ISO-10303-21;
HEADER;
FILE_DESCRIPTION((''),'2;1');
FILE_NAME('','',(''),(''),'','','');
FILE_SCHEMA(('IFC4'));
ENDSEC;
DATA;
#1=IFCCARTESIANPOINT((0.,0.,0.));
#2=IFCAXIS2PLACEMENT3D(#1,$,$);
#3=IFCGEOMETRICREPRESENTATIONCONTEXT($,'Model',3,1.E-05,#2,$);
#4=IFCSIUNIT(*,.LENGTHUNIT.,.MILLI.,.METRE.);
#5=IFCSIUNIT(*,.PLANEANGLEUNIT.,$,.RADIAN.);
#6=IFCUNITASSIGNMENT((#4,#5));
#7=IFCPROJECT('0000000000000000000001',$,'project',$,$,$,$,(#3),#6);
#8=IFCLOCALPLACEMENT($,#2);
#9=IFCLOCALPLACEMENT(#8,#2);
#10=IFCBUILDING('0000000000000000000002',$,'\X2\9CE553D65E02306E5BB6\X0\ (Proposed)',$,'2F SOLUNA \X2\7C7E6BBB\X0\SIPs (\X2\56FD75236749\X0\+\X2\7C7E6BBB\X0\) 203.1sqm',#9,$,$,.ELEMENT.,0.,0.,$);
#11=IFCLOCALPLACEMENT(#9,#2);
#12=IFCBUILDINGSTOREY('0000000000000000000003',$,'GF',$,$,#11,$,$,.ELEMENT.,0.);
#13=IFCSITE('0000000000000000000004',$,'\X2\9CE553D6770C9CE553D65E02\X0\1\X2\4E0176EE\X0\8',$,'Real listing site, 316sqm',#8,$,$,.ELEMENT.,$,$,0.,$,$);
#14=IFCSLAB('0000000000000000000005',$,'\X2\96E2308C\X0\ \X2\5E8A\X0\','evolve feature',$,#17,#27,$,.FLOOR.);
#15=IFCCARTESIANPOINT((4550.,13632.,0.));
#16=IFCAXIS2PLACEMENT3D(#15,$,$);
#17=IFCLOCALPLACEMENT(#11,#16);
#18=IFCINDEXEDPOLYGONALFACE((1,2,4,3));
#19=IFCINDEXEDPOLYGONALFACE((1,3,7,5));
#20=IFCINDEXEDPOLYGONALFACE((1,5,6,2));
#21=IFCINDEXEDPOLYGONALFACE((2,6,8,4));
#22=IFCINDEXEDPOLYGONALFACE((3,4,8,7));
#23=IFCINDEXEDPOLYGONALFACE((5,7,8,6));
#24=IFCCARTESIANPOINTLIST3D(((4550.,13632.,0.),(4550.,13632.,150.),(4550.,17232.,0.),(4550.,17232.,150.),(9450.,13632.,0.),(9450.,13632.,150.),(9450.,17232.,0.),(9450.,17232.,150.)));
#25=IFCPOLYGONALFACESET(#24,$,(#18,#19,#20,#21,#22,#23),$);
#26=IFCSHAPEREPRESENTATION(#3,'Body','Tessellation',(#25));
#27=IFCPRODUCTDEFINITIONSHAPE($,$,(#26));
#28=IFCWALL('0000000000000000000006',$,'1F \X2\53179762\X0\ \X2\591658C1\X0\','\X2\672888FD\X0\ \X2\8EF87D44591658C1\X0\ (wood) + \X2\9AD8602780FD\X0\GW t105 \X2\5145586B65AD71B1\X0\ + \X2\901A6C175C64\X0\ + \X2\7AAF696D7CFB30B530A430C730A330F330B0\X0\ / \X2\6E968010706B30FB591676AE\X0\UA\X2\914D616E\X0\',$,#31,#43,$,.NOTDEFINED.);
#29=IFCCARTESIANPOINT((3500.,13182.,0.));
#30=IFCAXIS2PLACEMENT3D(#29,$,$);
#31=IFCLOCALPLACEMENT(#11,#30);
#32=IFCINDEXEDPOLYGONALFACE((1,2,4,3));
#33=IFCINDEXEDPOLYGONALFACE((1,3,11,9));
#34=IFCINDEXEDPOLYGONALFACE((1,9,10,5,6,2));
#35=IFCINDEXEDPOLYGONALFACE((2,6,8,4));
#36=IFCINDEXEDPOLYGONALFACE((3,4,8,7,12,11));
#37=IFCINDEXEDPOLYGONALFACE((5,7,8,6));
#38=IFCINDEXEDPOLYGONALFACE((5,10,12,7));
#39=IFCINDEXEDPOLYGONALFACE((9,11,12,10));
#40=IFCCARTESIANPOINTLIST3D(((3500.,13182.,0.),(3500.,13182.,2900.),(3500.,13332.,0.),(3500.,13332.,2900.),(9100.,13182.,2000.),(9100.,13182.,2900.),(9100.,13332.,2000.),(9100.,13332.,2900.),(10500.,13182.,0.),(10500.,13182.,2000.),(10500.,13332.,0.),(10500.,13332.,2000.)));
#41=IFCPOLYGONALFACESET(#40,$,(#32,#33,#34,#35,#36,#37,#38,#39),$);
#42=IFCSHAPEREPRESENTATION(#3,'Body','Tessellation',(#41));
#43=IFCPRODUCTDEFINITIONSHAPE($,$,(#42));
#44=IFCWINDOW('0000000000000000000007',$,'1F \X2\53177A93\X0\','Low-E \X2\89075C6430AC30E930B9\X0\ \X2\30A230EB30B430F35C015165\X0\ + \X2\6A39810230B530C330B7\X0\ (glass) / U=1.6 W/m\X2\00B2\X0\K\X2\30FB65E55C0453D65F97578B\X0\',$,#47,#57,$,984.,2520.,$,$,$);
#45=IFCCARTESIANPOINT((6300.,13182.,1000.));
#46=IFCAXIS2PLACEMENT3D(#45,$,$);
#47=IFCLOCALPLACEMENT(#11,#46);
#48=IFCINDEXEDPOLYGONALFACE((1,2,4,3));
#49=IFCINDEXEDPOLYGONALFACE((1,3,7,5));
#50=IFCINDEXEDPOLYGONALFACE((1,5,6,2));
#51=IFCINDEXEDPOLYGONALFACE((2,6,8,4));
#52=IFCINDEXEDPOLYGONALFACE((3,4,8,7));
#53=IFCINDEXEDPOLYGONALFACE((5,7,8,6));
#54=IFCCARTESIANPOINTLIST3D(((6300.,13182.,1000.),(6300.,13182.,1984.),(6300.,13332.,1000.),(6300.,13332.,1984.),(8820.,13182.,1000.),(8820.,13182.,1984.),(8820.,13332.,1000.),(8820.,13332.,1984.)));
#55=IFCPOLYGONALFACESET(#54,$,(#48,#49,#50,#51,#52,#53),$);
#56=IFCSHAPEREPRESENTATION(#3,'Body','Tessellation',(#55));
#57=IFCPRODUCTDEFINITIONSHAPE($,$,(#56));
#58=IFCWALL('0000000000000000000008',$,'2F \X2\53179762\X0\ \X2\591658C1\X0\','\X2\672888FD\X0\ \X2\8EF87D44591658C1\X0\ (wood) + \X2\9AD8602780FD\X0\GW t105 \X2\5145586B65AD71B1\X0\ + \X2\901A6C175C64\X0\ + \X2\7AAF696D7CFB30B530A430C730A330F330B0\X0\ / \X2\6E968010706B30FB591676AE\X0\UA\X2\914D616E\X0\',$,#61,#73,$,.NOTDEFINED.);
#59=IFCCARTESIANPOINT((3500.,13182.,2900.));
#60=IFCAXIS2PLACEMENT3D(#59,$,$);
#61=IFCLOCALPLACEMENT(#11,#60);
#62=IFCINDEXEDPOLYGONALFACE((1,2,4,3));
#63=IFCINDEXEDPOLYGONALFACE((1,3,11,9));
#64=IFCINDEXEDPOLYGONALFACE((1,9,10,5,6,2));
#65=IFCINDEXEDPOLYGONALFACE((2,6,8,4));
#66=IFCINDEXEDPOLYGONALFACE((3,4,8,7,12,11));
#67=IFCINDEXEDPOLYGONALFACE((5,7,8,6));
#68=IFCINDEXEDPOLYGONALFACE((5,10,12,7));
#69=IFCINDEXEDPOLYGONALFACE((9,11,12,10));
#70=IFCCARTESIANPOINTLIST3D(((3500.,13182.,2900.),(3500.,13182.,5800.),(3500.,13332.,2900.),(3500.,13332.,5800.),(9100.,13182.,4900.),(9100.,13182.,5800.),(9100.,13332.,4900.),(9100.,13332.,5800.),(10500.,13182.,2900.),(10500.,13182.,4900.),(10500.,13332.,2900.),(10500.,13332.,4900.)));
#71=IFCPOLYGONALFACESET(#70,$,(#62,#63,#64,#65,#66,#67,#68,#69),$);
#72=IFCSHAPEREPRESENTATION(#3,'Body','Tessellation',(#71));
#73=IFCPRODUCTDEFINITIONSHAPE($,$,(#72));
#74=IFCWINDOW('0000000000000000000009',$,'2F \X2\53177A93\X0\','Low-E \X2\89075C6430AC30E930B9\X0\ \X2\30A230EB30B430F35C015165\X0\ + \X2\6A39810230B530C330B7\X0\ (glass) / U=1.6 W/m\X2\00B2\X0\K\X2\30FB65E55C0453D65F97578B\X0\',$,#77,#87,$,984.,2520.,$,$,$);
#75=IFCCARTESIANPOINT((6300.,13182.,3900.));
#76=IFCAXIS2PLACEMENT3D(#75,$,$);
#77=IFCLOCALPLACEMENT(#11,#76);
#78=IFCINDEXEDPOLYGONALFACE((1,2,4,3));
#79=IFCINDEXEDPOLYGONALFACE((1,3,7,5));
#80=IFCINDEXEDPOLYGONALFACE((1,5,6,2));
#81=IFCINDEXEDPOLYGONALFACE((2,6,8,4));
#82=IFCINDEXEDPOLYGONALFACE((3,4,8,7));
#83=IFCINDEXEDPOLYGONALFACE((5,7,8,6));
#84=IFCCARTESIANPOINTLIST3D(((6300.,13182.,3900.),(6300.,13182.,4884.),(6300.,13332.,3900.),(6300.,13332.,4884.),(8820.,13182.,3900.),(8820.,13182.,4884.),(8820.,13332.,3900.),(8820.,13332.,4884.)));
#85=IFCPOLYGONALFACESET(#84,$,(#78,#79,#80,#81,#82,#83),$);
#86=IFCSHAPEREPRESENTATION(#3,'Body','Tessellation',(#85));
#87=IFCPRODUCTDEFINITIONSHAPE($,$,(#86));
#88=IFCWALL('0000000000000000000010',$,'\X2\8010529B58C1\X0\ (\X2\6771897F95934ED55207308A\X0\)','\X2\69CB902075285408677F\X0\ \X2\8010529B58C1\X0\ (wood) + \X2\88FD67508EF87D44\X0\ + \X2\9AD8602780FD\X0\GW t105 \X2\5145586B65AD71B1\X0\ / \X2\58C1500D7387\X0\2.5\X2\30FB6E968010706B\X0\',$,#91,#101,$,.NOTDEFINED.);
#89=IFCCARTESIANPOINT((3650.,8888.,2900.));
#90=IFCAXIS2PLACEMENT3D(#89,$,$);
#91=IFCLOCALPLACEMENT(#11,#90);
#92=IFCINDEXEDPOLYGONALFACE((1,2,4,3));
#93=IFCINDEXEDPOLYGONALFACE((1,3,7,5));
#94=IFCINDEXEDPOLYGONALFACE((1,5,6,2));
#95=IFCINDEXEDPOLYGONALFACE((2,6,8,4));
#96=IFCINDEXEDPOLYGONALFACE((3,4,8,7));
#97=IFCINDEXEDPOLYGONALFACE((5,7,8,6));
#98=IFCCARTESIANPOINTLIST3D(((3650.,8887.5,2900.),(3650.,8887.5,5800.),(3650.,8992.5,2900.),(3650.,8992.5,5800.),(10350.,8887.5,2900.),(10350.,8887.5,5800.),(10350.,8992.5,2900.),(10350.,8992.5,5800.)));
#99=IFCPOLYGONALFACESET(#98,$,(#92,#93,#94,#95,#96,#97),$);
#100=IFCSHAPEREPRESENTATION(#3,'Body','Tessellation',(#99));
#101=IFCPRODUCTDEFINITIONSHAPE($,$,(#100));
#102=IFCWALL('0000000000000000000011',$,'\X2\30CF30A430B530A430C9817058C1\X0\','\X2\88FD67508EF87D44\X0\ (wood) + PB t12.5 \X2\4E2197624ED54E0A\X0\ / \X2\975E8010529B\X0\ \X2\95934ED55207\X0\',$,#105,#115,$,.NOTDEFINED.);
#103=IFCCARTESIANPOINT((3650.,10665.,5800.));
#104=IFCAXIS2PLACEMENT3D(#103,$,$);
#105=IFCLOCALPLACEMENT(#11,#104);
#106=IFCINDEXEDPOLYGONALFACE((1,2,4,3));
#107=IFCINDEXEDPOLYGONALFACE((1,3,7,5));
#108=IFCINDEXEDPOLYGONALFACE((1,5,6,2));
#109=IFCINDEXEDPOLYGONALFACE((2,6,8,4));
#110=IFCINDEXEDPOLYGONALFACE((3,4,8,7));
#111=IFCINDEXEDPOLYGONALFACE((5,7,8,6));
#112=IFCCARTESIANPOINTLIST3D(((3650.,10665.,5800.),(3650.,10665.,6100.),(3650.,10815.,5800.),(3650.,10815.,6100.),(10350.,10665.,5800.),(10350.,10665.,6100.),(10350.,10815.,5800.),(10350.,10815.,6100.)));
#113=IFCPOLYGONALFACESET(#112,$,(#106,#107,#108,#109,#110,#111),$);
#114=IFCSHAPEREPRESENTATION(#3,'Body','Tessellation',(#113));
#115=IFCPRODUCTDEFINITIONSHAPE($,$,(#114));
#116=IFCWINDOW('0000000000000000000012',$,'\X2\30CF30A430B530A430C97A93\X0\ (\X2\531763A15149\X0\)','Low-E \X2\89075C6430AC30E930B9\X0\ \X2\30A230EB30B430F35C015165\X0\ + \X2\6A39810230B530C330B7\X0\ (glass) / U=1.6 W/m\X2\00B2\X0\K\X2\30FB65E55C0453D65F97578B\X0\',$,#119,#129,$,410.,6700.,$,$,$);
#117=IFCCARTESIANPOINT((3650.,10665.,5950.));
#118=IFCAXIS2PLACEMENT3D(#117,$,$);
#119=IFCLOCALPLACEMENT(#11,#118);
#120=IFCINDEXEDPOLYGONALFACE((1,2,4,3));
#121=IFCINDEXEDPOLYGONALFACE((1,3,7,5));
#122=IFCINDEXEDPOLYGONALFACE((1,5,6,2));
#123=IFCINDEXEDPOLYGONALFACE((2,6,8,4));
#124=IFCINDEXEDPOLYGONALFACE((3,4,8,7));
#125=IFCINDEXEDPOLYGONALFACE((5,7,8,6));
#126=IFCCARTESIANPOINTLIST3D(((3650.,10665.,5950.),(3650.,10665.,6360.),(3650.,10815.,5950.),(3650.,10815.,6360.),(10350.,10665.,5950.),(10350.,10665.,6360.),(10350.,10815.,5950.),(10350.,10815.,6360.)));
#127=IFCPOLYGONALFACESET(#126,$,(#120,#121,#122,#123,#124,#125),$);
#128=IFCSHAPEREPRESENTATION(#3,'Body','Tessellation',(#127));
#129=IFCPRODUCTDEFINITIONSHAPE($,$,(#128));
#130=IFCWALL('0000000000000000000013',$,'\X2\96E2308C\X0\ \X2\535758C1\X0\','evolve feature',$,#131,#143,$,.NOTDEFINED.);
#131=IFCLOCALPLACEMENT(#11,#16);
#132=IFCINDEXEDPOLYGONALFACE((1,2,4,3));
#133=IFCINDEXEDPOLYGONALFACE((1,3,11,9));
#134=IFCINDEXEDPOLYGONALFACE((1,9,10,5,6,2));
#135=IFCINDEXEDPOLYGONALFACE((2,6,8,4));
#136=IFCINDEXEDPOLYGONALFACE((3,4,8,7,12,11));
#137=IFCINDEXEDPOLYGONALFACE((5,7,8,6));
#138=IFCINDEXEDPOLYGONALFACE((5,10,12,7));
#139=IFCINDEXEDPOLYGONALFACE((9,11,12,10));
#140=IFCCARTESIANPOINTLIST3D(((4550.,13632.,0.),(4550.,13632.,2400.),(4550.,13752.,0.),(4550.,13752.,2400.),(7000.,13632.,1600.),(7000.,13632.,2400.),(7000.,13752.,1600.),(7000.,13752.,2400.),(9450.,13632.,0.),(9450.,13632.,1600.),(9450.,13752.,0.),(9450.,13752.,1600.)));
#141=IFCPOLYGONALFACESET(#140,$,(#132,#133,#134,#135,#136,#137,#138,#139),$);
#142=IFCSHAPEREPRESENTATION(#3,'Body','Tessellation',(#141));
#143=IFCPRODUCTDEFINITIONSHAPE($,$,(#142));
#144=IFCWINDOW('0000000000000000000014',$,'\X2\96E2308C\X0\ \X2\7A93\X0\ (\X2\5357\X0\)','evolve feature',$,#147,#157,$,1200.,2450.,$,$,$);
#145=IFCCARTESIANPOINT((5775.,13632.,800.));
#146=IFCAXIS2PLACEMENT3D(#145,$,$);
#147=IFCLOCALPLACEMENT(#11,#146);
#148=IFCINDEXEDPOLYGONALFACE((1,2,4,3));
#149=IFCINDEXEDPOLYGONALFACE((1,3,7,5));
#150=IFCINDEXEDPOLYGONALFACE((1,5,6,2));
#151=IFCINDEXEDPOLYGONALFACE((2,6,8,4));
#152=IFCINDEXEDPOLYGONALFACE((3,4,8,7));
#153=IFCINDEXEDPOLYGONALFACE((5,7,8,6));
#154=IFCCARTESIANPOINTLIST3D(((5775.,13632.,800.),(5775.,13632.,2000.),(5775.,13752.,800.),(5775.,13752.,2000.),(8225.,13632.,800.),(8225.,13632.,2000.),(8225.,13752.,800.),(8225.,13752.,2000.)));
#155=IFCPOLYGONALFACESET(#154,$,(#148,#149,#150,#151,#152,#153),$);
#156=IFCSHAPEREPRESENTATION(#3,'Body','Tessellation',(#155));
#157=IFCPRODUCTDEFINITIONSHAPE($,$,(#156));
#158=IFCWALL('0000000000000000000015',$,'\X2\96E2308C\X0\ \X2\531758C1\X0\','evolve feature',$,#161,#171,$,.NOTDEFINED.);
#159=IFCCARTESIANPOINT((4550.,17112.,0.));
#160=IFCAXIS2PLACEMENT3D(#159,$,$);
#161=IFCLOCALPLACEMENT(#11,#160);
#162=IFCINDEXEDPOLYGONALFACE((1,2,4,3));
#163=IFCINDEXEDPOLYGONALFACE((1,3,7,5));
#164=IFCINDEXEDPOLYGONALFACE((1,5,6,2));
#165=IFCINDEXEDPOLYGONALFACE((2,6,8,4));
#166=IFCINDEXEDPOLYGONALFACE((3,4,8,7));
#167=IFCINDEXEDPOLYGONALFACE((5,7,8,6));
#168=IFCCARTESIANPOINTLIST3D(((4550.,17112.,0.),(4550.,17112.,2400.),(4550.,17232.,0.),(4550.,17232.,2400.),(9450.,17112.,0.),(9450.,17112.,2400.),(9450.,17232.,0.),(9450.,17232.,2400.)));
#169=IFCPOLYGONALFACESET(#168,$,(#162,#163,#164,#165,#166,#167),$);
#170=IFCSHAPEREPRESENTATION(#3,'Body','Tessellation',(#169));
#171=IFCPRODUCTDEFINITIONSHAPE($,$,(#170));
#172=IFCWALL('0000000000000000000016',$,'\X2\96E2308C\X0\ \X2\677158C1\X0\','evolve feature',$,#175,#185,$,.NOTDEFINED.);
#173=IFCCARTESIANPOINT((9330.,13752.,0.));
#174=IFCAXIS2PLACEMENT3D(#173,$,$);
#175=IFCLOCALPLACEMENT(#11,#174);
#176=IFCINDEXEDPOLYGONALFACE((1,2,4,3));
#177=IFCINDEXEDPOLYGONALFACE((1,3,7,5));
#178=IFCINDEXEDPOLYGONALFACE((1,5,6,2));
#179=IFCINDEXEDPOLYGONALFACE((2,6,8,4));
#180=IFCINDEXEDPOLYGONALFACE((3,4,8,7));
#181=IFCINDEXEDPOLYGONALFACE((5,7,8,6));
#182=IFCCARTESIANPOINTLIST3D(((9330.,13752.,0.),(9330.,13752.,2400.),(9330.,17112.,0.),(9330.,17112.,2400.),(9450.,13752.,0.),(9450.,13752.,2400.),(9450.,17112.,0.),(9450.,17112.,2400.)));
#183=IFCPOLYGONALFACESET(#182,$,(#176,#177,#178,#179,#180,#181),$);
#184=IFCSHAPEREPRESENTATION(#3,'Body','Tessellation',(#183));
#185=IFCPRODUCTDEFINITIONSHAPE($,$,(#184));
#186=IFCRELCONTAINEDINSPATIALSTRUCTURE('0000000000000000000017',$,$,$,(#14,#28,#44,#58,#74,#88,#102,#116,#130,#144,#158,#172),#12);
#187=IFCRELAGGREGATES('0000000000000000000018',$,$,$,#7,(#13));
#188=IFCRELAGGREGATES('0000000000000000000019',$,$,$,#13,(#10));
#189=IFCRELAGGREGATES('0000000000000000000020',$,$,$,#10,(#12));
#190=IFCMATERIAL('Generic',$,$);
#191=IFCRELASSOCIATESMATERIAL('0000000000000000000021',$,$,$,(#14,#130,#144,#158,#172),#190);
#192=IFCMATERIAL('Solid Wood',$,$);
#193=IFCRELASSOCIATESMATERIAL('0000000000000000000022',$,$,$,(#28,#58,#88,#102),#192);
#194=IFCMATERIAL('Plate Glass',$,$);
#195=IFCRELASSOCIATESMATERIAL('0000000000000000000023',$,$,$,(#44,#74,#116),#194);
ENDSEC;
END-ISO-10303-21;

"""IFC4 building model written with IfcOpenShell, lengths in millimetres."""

from ifc_helpers import new_model, si_unit, frame, frame_2d, origin, place, context, project, spatial, rectangle, extrude, material, element, fill, save


model = new_model("IFC4")

# Units and contexts
model_context = context("Model", 3, precision=1e-05, world=origin())
ifc_project = project(units=[si_unit("LENGTHUNIT", "METRE", prefix="MILLI"), si_unit("PLANEANGLEUNIT", "RADIAN")], contexts=[model_context])

# Site, building, storey
site_placement = place(None, origin())
site = spatial("IfcSite", under=ifc_project, at=site_placement, Name="鳥取県鳥取市1丁目8", ObjectType="Real listing site, 316sqm", CompositionType="ELEMENT", RefElevation=0.0)
building_placement = place(site_placement, origin())
building = spatial("IfcBuilding", under=site, at=building_placement, Name="鳥取市の家 (Proposed)", ObjectType="2F SOLUNA 籾殻SIPs (国産杉+籾殻) 203.1sqm", CompositionType="ELEMENT", ElevationOfRefHeight=0.0, ElevationOfTerrain=0.0)
storey_placement = place(building_placement, origin())
storey = spatial("IfcBuildingStorey", under=building, at=storey_placement, Name="GF", CompositionType="ELEMENT", Elevation=0.0)

# Slab
ifc_material_1 = material(Name="Generic")
slab_placement = place(storey_placement, frame((4550.0, 13632.0, 0.0)))
element("IfcSlab", 1, at=slab_placement, inside=storey, material=ifc_material_1, Name="離れ 床", Description="evolve feature", PredefinedType="FLOOR", context=model_context, shape_type="SweptSolid", body=[
    extrude(rectangle(XDim=4900.0, YDim=3600.0, at=frame_2d((2450.0, 1800.0))), frame((4550.0, 13632.0, 0.0)), (0.0, 0.0, 1.0), 150.0),
])

# Wall, opening, window
ifc_material_2 = material(Name="Solid Wood")
wall_1_placement = place(storey_placement, frame((3500.0, 13182.0, 0.0)))
wall_1 = element("IfcWall", 2, at=wall_1_placement, inside=storey, material=ifc_material_2, Name="1F 北面 外壁", Description="木製 軸組外壁 (wood) + 高性能GW t105 充填断熱 + 通気層 + 窯業系サイディング / 準耐火・外皮UA配慮", PredefinedType="NOTDEFINED", context=model_context, shape_type="SweptSolid", body=[
    extrude(rectangle(XDim=7000.0, YDim=150.0, at=frame_2d((3500.0, 75.0))), frame((3500.0, 13182.0, 0.0)), (0.0, 0.0, 1.0), 2900.0),
])
opening_1_placement = place(storey_placement, frame((6300.0, 13182.0, 1000.0)))
opening_1 = element("IfcOpeningElement", 3, at=opening_1_placement, cuts=wall_1, PredefinedType="NOTDEFINED", context=model_context, shape_type="SweptSolid", body=[
    extrude(rectangle(XDim=2520.0, YDim=150.0, at=frame_2d((1260.0, 75.0))), frame((6300.0, 13182.0, 1000.0)), (0.0, 0.0, 1.0), 984.0),
])
ifc_material_3 = material(Name="Plate Glass")
window_1_placement = place(storey_placement, frame((6300.0, 13182.0, 1000.0)))
window_1 = element("IfcWindow", 4, at=window_1_placement, inside=storey, material=ifc_material_3, Name="1F 北窓", Description="Low-E 複層ガラス アルゴン封入 + 樹脂サッシ (glass) / U=1.6 W/m²K・日射取得型", OverallHeight=984.0, OverallWidth=2520.0, context=model_context, shape_type="SweptSolid", body=[
    extrude(rectangle(XDim=2520.0, YDim=150.0, at=frame_2d((1260.0, 75.0))), frame((6300.0, 13182.0, 1000.0)), (0.0, 0.0, 1.0), 984.0),
])
fill(opening_1, window_1)

# Wall, opening, window
wall_2_placement = place(storey_placement, frame((3500.0, 13182.0, 2900.0)))
wall_2 = element("IfcWall", 5, at=wall_2_placement, inside=storey, material=ifc_material_2, Name="2F 北面 外壁", Description="木製 軸組外壁 (wood) + 高性能GW t105 充填断熱 + 通気層 + 窯業系サイディング / 準耐火・外皮UA配慮", PredefinedType="NOTDEFINED", context=model_context, shape_type="SweptSolid", body=[
    extrude(rectangle(XDim=7000.0, YDim=150.0, at=frame_2d((3500.0, 75.0))), frame((3500.0, 13182.0, 2900.0)), (0.0, 0.0, 1.0), 2900.0),
])
opening_2_placement = place(storey_placement, frame((6300.0, 13182.0, 3900.0)))
opening_2 = element("IfcOpeningElement", 6, at=opening_2_placement, cuts=wall_2, PredefinedType="NOTDEFINED", context=model_context, shape_type="SweptSolid", body=[
    extrude(rectangle(XDim=2520.0, YDim=150.0, at=frame_2d((1260.0, 75.0))), frame((6300.0, 13182.0, 3900.0)), (0.0, 0.0, 1.0), 984.0),
])
window_2_placement = place(storey_placement, frame((6300.0, 13182.0, 3900.0)))
window_2 = element("IfcWindow", 7, at=window_2_placement, inside=storey, material=ifc_material_3, Name="2F 北窓", Description="Low-E 複層ガラス アルゴン封入 + 樹脂サッシ (glass) / U=1.6 W/m²K・日射取得型", OverallHeight=984.0, OverallWidth=2520.0, context=model_context, shape_type="SweptSolid", body=[
    extrude(rectangle(XDim=2520.0, YDim=150.0, at=frame_2d((1260.0, 75.0))), frame((6300.0, 13182.0, 3900.0)), (0.0, 0.0, 1.0), 984.0),
])
fill(opening_2, window_2)

# Wall
wall_3_placement = place(storey_placement, frame((3650.0, 8888.0, 2900.0)))
element("IfcWall", 8, at=wall_3_placement, inside=storey, material=ifc_material_2, Name="耐力壁 (東西間仕切り)", Description="構造用合板 耐力壁 (wood) + 製材軸組 + 高性能GW t105 充填断熱 / 壁倍率2.5・準耐火", PredefinedType="NOTDEFINED", context=model_context, shape_type="SweptSolid", body=[
    extrude(rectangle(XDim=6700.0, YDim=105.0, at=frame_2d((3350.0, 52.0))), frame((3650.0, 8888.0, 2900.0)), (0.0, 0.0, 1.0), 2900.0),
])

# Walls, openings, windows
wall_4_placement = place(storey_placement, frame((3650.0, 10665.0, 5800.0)))
wall_4 = element("IfcWall", 9, at=wall_4_placement, inside=storey, material=ifc_material_2, Name="ハイサイド腰壁", Description="製材軸組 (wood) + PB t12.5 両面仕上 / 非耐力 間仕切", PredefinedType="NOTDEFINED", context=model_context, shape_type="SweptSolid", body=[
    extrude(rectangle(XDim=6700.0, YDim=150.0, at=frame_2d((3350.0, 75.0))), frame((3650.0, 10665.0, 5800.0)), (0.0, 0.0, 1.0), 700.0),
])
opening_3_placement = place(storey_placement, frame((3650.0, 10665.0, 5950.0)))
opening_3 = element("IfcOpeningElement", 10, at=opening_3_placement, cuts=wall_4, PredefinedType="NOTDEFINED", context=model_context, shape_type="SweptSolid", body=[
    extrude(rectangle(XDim=6700.0, YDim=150.0, at=frame_2d((3350.0, 75.0))), frame((3650.0, 10665.0, 5950.0)), (0.0, 0.0, 1.0), 410.0),
])
window_3_placement = place(storey_placement, frame((3650.0, 10665.0, 5950.0)))
window_3 = element("IfcWindow", 11, at=window_3_placement, inside=storey, material=ifc_material_3, Name="ハイサイド窓 (北採光)", Description="Low-E 複層ガラス アルゴン封入 + 樹脂サッシ (glass) / U=1.6 W/m²K・日射取得型", OverallHeight=410.0, OverallWidth=6700.0, context=model_context, shape_type="SweptSolid", body=[
    extrude(rectangle(XDim=6700.0, YDim=150.0, at=frame_2d((3350.0, 75.0))), frame((3650.0, 10665.0, 5950.0)), (0.0, 0.0, 1.0), 410.0),
])
fill(opening_3, window_3)
wall_5_placement = place(storey_placement, frame((4550.0, 13632.0, 0.0)))
wall_5 = element("IfcWall", 12, at=wall_5_placement, inside=storey, material=ifc_material_1, Name="離れ 南壁", Description="evolve feature", PredefinedType="NOTDEFINED", context=model_context, shape_type="SweptSolid", body=[
    extrude(rectangle(XDim=4900.0, YDim=120.0, at=frame_2d((2450.0, 60.0))), frame((4550.0, 13632.0, 0.0)), (0.0, 0.0, 1.0), 2400.0),
])
opening_4_placement = place(storey_placement, frame((5775.0, 13632.0, 800.0)))
opening_4 = element("IfcOpeningElement", 13, at=opening_4_placement, cuts=wall_5, PredefinedType="NOTDEFINED", context=model_context, shape_type="SweptSolid", body=[
    extrude(rectangle(XDim=2450.0, YDim=120.0, at=frame_2d((1225.0, 60.0))), frame((5775.0, 13632.0, 800.0)), (0.0, 0.0, 1.0), 1200.0),
])
window_4_placement = place(storey_placement, frame((5775.0, 13632.0, 800.0)))
window_4 = element("IfcWindow", 14, at=window_4_placement, inside=storey, material=ifc_material_1, Name="離れ 窓 (南)", Description="evolve feature", OverallHeight=1200.0, OverallWidth=2450.0, context=model_context, shape_type="SweptSolid", body=[
    extrude(rectangle(XDim=2450.0, YDim=120.0, at=frame_2d((1225.0, 60.0))), frame((5775.0, 13632.0, 800.0)), (0.0, 0.0, 1.0), 1200.0),
])
fill(opening_4, window_4)

# Walls
wall_6_placement = place(storey_placement, frame((4550.0, 17112.0, 0.0)))
element("IfcWall", 15, at=wall_6_placement, inside=storey, material=ifc_material_1, Name="離れ 北壁", Description="evolve feature", PredefinedType="NOTDEFINED", context=model_context, shape_type="SweptSolid", body=[
    extrude(rectangle(XDim=4900.0, YDim=120.0, at=frame_2d((2450.0, 60.0))), frame((4550.0, 17112.0, 0.0)), (0.0, 0.0, 1.0), 2400.0),
])
wall_7_placement = place(storey_placement, frame((9330.0, 13752.0, 0.0)))
element("IfcWall", 16, at=wall_7_placement, inside=storey, material=ifc_material_1, Name="離れ 東壁", Description="evolve feature", PredefinedType="NOTDEFINED", context=model_context, shape_type="SweptSolid", body=[
    extrude(rectangle(XDim=120.0, YDim=3360.0, at=frame_2d((60.0, 1680.0))), frame((9330.0, 13752.0, 0.0)), (0.0, 0.0, 1.0), 2400.0),
])

save(model, "model.ifc")
